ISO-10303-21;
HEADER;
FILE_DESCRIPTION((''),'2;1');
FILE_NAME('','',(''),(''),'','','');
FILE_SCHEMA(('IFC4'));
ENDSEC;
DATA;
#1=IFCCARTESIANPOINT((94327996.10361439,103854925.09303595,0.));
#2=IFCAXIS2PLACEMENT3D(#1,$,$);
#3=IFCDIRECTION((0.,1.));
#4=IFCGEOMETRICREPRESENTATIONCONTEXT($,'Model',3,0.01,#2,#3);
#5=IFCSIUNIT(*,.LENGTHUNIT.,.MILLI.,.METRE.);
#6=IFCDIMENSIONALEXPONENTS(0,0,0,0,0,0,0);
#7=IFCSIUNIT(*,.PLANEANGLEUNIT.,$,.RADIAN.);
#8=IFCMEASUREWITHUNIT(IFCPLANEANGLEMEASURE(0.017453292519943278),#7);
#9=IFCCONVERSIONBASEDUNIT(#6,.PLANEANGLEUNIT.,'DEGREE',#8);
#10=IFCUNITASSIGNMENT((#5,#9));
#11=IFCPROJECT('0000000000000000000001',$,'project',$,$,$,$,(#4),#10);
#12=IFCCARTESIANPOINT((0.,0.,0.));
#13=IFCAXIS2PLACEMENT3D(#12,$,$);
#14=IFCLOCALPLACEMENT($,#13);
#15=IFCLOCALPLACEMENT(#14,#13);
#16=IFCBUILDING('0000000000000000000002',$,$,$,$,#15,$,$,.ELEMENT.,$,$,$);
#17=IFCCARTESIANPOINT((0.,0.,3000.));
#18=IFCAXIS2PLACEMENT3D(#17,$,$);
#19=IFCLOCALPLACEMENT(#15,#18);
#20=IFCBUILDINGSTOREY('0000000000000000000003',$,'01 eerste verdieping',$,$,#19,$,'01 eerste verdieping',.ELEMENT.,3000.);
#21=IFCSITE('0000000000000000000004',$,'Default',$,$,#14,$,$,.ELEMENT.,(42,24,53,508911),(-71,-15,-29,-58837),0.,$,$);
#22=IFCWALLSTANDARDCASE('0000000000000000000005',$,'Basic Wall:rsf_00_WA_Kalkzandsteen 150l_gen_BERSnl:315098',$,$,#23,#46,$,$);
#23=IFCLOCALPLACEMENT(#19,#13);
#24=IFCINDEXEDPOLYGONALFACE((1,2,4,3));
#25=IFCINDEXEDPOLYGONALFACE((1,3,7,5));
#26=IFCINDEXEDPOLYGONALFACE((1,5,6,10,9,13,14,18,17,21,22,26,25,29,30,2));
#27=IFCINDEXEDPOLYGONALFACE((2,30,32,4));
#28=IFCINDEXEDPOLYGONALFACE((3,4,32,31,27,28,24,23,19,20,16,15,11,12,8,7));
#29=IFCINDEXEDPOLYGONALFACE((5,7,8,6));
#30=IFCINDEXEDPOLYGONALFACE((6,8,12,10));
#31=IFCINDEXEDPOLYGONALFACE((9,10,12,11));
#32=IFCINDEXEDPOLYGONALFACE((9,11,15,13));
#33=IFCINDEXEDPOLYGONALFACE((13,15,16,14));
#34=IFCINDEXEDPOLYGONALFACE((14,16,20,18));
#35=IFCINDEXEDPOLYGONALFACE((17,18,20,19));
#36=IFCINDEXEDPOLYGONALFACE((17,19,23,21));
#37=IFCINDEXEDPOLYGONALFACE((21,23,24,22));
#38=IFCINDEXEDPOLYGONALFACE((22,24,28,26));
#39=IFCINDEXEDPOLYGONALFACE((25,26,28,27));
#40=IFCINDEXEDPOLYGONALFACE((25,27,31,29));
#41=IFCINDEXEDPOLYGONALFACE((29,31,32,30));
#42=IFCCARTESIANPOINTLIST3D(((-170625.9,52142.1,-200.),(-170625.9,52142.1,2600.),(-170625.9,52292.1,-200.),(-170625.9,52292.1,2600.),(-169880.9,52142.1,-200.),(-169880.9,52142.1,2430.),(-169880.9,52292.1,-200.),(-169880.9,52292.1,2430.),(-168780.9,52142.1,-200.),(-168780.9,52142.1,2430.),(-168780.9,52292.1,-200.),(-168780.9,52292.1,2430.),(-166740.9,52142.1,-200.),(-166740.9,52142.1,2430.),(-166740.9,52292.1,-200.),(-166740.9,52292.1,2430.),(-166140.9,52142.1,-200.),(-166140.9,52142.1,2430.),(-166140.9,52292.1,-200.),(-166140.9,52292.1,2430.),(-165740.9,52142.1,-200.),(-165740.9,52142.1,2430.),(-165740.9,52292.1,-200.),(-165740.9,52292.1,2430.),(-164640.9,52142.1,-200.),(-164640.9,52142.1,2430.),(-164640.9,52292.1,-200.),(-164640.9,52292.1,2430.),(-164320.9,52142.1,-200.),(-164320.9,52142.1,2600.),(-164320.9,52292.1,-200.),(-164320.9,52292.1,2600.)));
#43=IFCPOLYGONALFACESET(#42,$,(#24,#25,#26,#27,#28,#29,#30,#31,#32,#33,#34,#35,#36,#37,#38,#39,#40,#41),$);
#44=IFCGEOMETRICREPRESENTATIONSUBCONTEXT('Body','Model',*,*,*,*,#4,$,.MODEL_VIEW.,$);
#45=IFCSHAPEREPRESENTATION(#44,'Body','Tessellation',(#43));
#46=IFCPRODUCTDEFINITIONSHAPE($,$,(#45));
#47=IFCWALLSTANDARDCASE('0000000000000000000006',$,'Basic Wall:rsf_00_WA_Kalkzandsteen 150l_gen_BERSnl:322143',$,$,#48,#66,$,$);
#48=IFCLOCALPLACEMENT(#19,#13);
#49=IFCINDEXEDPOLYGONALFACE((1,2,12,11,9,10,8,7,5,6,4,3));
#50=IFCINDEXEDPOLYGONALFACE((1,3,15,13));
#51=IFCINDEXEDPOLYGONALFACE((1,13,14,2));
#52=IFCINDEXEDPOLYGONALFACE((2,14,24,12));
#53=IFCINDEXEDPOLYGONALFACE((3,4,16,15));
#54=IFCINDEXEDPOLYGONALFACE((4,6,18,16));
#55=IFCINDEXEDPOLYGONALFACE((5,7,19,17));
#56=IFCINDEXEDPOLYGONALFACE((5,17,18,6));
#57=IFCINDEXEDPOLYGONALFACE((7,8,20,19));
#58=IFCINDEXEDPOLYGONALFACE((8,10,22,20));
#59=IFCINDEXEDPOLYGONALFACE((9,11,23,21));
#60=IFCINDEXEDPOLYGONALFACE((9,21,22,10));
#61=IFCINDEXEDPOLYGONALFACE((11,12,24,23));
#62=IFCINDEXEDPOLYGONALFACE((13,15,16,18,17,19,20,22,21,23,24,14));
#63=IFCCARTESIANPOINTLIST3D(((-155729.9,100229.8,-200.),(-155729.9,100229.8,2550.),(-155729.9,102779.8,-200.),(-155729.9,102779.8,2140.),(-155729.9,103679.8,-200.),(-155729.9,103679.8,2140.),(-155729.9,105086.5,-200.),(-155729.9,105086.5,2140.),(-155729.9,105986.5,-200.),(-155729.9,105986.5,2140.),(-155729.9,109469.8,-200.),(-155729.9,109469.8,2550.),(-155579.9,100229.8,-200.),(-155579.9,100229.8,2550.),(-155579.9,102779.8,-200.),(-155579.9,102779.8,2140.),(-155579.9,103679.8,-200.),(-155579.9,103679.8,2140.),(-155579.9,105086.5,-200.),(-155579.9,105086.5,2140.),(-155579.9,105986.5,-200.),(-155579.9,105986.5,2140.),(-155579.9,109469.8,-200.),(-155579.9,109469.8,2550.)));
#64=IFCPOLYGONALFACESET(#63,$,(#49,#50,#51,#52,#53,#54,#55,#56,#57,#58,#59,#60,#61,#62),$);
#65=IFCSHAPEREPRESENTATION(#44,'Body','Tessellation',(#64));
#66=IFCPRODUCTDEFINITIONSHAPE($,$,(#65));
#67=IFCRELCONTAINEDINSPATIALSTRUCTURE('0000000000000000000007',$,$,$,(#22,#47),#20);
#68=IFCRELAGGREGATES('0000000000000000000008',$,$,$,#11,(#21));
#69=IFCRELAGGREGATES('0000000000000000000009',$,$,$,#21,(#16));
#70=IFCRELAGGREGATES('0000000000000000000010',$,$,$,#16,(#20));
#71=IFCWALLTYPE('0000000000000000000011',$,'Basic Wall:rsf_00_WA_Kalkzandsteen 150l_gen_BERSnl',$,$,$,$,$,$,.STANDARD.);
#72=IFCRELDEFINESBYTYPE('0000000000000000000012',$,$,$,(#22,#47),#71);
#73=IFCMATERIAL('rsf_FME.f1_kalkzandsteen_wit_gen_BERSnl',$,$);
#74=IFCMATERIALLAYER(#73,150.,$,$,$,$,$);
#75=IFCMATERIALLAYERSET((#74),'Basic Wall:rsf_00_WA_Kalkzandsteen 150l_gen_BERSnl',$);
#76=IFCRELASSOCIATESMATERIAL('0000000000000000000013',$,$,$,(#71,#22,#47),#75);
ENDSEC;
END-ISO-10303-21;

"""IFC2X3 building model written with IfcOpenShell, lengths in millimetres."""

from ifc_helpers import new_model, entity, si_unit, converted_unit, direction, frame, frame_2d, origin, place, context, subcontext, project, spatial, polyline, rectangle, extrude, clip, bounded_halfspace, material, layer, layer_set, layer_usage, type_object, element, save


model = new_model("IFC2X3")

# Units and contexts
model_context = context("Model", 3, precision=0.01, world=frame((94327996.10361439, 103854925.09303595, 0.0)), true_north=direction((0.0, 1.0)))
body_context = subcontext(model_context, "Body", "Model", "MODEL_VIEW")
ifc_project = project(units=[si_unit("LENGTHUNIT", "METRE", prefix="MILLI"), converted_unit("PLANEANGLEUNIT", "DEGREE", entity("IfcPlaneAngleMeasure", 0.017453292519943278), si_unit("PLANEANGLEUNIT", "RADIAN"), dimensions=[0, 0, 0, 0, 0, 0, 0])], contexts=[model_context])

# Site, building, storey
site_placement = place(None, origin())
site = spatial("IfcSite", under=ifc_project, at=site_placement, Name="Default", CompositionType="ELEMENT", RefLatitude=(42, 24, 53, 508911), RefLongitude=(-71, -15, -29, -58837), RefElevation=0.0)
building_placement = place(site_placement, origin())
building = spatial("IfcBuilding", under=site, at=building_placement, CompositionType="ELEMENT")
storey_placement = place(building_placement, frame((0.0, 0.0, 3000.0)))
storey = spatial("IfcBuildingStorey", under=building, at=storey_placement, Name="01 eerste verdieping", LongName="01 eerste verdieping", CompositionType="ELEMENT", Elevation=3000.0)

# Shared definitions
ifc_material = material(Name="rsf_FME.f1_kalkzandsteen_wit_gen_BERSnl")
ifc_layer = layer(ifc_material, 150.0)
ifc_layer_set = layer_set([ifc_layer], Name="Basic Wall:rsf_00_WA_Kalkzandsteen 150l_gen_BERSnl")
wall_type = type_object("IfcWallType", Name="Basic Wall:rsf_00_WA_Kalkzandsteen 150l_gen_BERSnl", PredefinedType="STANDARD", material=ifc_layer_set)

# Walls, openings
ifc_layer_usage_1 = layer_usage(ifc_layer_set, "AXIS2", "NEGATIVE", 75.0)
wall_1_placement = place(storey_placement, frame((-164320.9, 52217.1, -200.0), z_axis=(0.0, 0.0, 1.0), x_axis=(-1.0, 0.0, 0.0)))
wall_1 = element("IfcWallStandardCase", 1, at=wall_1_placement, inside=storey, type_object=wall_type, material=ifc_layer_usage_1, Name="Basic Wall:rsf_00_WA_Kalkzandsteen 150l_gen_BERSnl:315098", context=body_context, shape_type="Clipping", body=[
    clip(extrude(rectangle(XDim=6305.0, YDim=150.0, at=frame_2d((3152.5, 0.0), x_axis=(-1.0, 0.0))), origin(), (0.0, 0.0, 1.0), 2800.0), bounded_halfspace(frame((0.0, -75.0, 2800.0), z_axis=(0.0, 0.0, -1.0), x_axis=(0.0, -1.0, 0.0)), True, frame((0.0, -75.0, 2800.0)), polyline([(0.0, 0.0), (6305.0, 0.0), (6305.0, 150.0), (6155.0, 150.0), (3213.5, 150.0), (3063.5, 150.0), (0.0, 150.0), (0.0, 0.0)]))),
])
opening_1_placement = place(wall_1_placement, frame((-164320.9, 52217.1, 200.0), z_axis=(0.0, 0.0, 1.0), x_axis=(-1.0, 0.0, 0.0)))
element("IfcOpeningElement", 2, at=opening_1_placement, cuts=wall_1, ObjectType="Opening", context=body_context, shape_type="SweptSolid", body=[
    extrude(rectangle(XDim=2630.0, YDim=1100.0, at=frame_2d((0.0, 0.0), x_axis=(0.0, 1.0))), frame((-165190.9, 53816.1, 1115.0), z_axis=(0.0, -1.0, 0.0), x_axis=(1.0, 0.0, 0.0)), (0.0, 0.0, 1.0), 3048.0),
])
opening_2_placement = place(wall_1_placement, frame((-164320.9, 52217.1, 200.0), z_axis=(0.0, 0.0, 1.0), x_axis=(-1.0, 0.0, 0.0)))
element("IfcOpeningElement", 3, at=opening_2_placement, cuts=wall_1, ObjectType="Opening", context=body_context, shape_type="SweptSolid", body=[
    extrude(rectangle(XDim=2630.0, YDim=1100.0, at=frame_2d((0.0, 0.0), x_axis=(0.0, 1.0))), frame((-169330.9, 53816.1, 1115.0), z_axis=(0.0, -1.0, 0.0), x_axis=(1.0, 0.0, 0.0)), (0.0, 0.0, 1.0), 3048.0),
])
opening_3_placement = place(wall_1_placement, frame((-164320.9, 52217.1, 200.0), z_axis=(0.0, 0.0, 1.0), x_axis=(-1.0, 0.0, 0.0)))
element("IfcOpeningElement", 4, at=opening_3_placement, cuts=wall_1, ObjectType="Opening", context=body_context, shape_type="SweptSolid", body=[
    extrude(rectangle(XDim=2630.0, YDim=600.0, at=frame_2d((0.0, 0.0), x_axis=(0.0, 1.0))), frame((-166440.9, 53816.1, 1115.0), z_axis=(0.0, -1.0, 0.0), x_axis=(1.0, 0.0, 0.0)), (0.0, 0.0, 1.0), 3048.0),
])
ifc_layer_usage_2 = layer_usage(ifc_layer_set, "AXIS2", "POSITIVE", -75.0)
wall_2_placement = place(storey_placement, frame((-155654.9, 100229.8, -200.0), z_axis=(0.0, 0.0, 1.0), x_axis=(0.0, 1.0, 0.0)))
wall_2 = element("IfcWallStandardCase", 5, at=wall_2_placement, inside=storey, type_object=wall_type, material=ifc_layer_usage_2, Name="Basic Wall:rsf_00_WA_Kalkzandsteen 150l_gen_BERSnl:322143", context=body_context, shape_type="Clipping", body=[
    clip(extrude(rectangle(XDim=9240.0, YDim=150.0, at=frame_2d((4620.0, 0.0), x_axis=(-1.0, 0.0))), origin(), (0.0, 0.0, 1.0), 2750.0), bounded_halfspace(frame((0.0, -75.0, 2750.0), z_axis=(0.0, 0.0, -1.0), x_axis=(1.0, 0.0, 0.0)), True, frame((0.0, -75.0, 2750.0)), polyline([(0.0, 0.0), (9240.0, 0.0), (9240.0, 150.0), (0.0, 150.0), (0.0, 0.0)]))),
])
opening_4_placement = place(wall_2_placement, frame((-100229.8, -155654.9, 200.0), z_axis=(0.0, 0.0, 1.0), x_axis=(0.0, -1.0, 0.0)))
element("IfcOpeningElement", 6, at=opening_4_placement, cuts=wall_2, ObjectType="Opening", context=body_context, shape_type="SweptSolid", body=[
    extrude(rectangle(XDim=2340.0, YDim=900.0, at=frame_2d((0.0, 0.0), x_axis=(0.0, 1.0))), frame((-154055.9, 105536.5, 970.0), z_axis=(-1.0, 0.0, 0.0), x_axis=(0.0, -1.0, 0.0)), (0.0, 0.0, 1.0), 3048.0),
])
opening_5_placement = place(wall_2_placement, frame((-100229.8, -155654.9, 200.0), z_axis=(0.0, 0.0, 1.0), x_axis=(0.0, -1.0, 0.0)))
element("IfcOpeningElement", 7, at=opening_5_placement, cuts=wall_2, ObjectType="Opening", context=body_context, shape_type="SweptSolid", body=[
    extrude(rectangle(XDim=2340.0, YDim=900.0, at=frame_2d((0.0, 0.0), x_axis=(0.0, 1.0))), frame((-154055.9, 103229.8, 970.0), z_axis=(-1.0, 0.0, 0.0), x_axis=(0.0, -1.0, 0.0)), (0.0, 0.0, 1.0), 3048.0),
])

save(model, "model.ifc")
